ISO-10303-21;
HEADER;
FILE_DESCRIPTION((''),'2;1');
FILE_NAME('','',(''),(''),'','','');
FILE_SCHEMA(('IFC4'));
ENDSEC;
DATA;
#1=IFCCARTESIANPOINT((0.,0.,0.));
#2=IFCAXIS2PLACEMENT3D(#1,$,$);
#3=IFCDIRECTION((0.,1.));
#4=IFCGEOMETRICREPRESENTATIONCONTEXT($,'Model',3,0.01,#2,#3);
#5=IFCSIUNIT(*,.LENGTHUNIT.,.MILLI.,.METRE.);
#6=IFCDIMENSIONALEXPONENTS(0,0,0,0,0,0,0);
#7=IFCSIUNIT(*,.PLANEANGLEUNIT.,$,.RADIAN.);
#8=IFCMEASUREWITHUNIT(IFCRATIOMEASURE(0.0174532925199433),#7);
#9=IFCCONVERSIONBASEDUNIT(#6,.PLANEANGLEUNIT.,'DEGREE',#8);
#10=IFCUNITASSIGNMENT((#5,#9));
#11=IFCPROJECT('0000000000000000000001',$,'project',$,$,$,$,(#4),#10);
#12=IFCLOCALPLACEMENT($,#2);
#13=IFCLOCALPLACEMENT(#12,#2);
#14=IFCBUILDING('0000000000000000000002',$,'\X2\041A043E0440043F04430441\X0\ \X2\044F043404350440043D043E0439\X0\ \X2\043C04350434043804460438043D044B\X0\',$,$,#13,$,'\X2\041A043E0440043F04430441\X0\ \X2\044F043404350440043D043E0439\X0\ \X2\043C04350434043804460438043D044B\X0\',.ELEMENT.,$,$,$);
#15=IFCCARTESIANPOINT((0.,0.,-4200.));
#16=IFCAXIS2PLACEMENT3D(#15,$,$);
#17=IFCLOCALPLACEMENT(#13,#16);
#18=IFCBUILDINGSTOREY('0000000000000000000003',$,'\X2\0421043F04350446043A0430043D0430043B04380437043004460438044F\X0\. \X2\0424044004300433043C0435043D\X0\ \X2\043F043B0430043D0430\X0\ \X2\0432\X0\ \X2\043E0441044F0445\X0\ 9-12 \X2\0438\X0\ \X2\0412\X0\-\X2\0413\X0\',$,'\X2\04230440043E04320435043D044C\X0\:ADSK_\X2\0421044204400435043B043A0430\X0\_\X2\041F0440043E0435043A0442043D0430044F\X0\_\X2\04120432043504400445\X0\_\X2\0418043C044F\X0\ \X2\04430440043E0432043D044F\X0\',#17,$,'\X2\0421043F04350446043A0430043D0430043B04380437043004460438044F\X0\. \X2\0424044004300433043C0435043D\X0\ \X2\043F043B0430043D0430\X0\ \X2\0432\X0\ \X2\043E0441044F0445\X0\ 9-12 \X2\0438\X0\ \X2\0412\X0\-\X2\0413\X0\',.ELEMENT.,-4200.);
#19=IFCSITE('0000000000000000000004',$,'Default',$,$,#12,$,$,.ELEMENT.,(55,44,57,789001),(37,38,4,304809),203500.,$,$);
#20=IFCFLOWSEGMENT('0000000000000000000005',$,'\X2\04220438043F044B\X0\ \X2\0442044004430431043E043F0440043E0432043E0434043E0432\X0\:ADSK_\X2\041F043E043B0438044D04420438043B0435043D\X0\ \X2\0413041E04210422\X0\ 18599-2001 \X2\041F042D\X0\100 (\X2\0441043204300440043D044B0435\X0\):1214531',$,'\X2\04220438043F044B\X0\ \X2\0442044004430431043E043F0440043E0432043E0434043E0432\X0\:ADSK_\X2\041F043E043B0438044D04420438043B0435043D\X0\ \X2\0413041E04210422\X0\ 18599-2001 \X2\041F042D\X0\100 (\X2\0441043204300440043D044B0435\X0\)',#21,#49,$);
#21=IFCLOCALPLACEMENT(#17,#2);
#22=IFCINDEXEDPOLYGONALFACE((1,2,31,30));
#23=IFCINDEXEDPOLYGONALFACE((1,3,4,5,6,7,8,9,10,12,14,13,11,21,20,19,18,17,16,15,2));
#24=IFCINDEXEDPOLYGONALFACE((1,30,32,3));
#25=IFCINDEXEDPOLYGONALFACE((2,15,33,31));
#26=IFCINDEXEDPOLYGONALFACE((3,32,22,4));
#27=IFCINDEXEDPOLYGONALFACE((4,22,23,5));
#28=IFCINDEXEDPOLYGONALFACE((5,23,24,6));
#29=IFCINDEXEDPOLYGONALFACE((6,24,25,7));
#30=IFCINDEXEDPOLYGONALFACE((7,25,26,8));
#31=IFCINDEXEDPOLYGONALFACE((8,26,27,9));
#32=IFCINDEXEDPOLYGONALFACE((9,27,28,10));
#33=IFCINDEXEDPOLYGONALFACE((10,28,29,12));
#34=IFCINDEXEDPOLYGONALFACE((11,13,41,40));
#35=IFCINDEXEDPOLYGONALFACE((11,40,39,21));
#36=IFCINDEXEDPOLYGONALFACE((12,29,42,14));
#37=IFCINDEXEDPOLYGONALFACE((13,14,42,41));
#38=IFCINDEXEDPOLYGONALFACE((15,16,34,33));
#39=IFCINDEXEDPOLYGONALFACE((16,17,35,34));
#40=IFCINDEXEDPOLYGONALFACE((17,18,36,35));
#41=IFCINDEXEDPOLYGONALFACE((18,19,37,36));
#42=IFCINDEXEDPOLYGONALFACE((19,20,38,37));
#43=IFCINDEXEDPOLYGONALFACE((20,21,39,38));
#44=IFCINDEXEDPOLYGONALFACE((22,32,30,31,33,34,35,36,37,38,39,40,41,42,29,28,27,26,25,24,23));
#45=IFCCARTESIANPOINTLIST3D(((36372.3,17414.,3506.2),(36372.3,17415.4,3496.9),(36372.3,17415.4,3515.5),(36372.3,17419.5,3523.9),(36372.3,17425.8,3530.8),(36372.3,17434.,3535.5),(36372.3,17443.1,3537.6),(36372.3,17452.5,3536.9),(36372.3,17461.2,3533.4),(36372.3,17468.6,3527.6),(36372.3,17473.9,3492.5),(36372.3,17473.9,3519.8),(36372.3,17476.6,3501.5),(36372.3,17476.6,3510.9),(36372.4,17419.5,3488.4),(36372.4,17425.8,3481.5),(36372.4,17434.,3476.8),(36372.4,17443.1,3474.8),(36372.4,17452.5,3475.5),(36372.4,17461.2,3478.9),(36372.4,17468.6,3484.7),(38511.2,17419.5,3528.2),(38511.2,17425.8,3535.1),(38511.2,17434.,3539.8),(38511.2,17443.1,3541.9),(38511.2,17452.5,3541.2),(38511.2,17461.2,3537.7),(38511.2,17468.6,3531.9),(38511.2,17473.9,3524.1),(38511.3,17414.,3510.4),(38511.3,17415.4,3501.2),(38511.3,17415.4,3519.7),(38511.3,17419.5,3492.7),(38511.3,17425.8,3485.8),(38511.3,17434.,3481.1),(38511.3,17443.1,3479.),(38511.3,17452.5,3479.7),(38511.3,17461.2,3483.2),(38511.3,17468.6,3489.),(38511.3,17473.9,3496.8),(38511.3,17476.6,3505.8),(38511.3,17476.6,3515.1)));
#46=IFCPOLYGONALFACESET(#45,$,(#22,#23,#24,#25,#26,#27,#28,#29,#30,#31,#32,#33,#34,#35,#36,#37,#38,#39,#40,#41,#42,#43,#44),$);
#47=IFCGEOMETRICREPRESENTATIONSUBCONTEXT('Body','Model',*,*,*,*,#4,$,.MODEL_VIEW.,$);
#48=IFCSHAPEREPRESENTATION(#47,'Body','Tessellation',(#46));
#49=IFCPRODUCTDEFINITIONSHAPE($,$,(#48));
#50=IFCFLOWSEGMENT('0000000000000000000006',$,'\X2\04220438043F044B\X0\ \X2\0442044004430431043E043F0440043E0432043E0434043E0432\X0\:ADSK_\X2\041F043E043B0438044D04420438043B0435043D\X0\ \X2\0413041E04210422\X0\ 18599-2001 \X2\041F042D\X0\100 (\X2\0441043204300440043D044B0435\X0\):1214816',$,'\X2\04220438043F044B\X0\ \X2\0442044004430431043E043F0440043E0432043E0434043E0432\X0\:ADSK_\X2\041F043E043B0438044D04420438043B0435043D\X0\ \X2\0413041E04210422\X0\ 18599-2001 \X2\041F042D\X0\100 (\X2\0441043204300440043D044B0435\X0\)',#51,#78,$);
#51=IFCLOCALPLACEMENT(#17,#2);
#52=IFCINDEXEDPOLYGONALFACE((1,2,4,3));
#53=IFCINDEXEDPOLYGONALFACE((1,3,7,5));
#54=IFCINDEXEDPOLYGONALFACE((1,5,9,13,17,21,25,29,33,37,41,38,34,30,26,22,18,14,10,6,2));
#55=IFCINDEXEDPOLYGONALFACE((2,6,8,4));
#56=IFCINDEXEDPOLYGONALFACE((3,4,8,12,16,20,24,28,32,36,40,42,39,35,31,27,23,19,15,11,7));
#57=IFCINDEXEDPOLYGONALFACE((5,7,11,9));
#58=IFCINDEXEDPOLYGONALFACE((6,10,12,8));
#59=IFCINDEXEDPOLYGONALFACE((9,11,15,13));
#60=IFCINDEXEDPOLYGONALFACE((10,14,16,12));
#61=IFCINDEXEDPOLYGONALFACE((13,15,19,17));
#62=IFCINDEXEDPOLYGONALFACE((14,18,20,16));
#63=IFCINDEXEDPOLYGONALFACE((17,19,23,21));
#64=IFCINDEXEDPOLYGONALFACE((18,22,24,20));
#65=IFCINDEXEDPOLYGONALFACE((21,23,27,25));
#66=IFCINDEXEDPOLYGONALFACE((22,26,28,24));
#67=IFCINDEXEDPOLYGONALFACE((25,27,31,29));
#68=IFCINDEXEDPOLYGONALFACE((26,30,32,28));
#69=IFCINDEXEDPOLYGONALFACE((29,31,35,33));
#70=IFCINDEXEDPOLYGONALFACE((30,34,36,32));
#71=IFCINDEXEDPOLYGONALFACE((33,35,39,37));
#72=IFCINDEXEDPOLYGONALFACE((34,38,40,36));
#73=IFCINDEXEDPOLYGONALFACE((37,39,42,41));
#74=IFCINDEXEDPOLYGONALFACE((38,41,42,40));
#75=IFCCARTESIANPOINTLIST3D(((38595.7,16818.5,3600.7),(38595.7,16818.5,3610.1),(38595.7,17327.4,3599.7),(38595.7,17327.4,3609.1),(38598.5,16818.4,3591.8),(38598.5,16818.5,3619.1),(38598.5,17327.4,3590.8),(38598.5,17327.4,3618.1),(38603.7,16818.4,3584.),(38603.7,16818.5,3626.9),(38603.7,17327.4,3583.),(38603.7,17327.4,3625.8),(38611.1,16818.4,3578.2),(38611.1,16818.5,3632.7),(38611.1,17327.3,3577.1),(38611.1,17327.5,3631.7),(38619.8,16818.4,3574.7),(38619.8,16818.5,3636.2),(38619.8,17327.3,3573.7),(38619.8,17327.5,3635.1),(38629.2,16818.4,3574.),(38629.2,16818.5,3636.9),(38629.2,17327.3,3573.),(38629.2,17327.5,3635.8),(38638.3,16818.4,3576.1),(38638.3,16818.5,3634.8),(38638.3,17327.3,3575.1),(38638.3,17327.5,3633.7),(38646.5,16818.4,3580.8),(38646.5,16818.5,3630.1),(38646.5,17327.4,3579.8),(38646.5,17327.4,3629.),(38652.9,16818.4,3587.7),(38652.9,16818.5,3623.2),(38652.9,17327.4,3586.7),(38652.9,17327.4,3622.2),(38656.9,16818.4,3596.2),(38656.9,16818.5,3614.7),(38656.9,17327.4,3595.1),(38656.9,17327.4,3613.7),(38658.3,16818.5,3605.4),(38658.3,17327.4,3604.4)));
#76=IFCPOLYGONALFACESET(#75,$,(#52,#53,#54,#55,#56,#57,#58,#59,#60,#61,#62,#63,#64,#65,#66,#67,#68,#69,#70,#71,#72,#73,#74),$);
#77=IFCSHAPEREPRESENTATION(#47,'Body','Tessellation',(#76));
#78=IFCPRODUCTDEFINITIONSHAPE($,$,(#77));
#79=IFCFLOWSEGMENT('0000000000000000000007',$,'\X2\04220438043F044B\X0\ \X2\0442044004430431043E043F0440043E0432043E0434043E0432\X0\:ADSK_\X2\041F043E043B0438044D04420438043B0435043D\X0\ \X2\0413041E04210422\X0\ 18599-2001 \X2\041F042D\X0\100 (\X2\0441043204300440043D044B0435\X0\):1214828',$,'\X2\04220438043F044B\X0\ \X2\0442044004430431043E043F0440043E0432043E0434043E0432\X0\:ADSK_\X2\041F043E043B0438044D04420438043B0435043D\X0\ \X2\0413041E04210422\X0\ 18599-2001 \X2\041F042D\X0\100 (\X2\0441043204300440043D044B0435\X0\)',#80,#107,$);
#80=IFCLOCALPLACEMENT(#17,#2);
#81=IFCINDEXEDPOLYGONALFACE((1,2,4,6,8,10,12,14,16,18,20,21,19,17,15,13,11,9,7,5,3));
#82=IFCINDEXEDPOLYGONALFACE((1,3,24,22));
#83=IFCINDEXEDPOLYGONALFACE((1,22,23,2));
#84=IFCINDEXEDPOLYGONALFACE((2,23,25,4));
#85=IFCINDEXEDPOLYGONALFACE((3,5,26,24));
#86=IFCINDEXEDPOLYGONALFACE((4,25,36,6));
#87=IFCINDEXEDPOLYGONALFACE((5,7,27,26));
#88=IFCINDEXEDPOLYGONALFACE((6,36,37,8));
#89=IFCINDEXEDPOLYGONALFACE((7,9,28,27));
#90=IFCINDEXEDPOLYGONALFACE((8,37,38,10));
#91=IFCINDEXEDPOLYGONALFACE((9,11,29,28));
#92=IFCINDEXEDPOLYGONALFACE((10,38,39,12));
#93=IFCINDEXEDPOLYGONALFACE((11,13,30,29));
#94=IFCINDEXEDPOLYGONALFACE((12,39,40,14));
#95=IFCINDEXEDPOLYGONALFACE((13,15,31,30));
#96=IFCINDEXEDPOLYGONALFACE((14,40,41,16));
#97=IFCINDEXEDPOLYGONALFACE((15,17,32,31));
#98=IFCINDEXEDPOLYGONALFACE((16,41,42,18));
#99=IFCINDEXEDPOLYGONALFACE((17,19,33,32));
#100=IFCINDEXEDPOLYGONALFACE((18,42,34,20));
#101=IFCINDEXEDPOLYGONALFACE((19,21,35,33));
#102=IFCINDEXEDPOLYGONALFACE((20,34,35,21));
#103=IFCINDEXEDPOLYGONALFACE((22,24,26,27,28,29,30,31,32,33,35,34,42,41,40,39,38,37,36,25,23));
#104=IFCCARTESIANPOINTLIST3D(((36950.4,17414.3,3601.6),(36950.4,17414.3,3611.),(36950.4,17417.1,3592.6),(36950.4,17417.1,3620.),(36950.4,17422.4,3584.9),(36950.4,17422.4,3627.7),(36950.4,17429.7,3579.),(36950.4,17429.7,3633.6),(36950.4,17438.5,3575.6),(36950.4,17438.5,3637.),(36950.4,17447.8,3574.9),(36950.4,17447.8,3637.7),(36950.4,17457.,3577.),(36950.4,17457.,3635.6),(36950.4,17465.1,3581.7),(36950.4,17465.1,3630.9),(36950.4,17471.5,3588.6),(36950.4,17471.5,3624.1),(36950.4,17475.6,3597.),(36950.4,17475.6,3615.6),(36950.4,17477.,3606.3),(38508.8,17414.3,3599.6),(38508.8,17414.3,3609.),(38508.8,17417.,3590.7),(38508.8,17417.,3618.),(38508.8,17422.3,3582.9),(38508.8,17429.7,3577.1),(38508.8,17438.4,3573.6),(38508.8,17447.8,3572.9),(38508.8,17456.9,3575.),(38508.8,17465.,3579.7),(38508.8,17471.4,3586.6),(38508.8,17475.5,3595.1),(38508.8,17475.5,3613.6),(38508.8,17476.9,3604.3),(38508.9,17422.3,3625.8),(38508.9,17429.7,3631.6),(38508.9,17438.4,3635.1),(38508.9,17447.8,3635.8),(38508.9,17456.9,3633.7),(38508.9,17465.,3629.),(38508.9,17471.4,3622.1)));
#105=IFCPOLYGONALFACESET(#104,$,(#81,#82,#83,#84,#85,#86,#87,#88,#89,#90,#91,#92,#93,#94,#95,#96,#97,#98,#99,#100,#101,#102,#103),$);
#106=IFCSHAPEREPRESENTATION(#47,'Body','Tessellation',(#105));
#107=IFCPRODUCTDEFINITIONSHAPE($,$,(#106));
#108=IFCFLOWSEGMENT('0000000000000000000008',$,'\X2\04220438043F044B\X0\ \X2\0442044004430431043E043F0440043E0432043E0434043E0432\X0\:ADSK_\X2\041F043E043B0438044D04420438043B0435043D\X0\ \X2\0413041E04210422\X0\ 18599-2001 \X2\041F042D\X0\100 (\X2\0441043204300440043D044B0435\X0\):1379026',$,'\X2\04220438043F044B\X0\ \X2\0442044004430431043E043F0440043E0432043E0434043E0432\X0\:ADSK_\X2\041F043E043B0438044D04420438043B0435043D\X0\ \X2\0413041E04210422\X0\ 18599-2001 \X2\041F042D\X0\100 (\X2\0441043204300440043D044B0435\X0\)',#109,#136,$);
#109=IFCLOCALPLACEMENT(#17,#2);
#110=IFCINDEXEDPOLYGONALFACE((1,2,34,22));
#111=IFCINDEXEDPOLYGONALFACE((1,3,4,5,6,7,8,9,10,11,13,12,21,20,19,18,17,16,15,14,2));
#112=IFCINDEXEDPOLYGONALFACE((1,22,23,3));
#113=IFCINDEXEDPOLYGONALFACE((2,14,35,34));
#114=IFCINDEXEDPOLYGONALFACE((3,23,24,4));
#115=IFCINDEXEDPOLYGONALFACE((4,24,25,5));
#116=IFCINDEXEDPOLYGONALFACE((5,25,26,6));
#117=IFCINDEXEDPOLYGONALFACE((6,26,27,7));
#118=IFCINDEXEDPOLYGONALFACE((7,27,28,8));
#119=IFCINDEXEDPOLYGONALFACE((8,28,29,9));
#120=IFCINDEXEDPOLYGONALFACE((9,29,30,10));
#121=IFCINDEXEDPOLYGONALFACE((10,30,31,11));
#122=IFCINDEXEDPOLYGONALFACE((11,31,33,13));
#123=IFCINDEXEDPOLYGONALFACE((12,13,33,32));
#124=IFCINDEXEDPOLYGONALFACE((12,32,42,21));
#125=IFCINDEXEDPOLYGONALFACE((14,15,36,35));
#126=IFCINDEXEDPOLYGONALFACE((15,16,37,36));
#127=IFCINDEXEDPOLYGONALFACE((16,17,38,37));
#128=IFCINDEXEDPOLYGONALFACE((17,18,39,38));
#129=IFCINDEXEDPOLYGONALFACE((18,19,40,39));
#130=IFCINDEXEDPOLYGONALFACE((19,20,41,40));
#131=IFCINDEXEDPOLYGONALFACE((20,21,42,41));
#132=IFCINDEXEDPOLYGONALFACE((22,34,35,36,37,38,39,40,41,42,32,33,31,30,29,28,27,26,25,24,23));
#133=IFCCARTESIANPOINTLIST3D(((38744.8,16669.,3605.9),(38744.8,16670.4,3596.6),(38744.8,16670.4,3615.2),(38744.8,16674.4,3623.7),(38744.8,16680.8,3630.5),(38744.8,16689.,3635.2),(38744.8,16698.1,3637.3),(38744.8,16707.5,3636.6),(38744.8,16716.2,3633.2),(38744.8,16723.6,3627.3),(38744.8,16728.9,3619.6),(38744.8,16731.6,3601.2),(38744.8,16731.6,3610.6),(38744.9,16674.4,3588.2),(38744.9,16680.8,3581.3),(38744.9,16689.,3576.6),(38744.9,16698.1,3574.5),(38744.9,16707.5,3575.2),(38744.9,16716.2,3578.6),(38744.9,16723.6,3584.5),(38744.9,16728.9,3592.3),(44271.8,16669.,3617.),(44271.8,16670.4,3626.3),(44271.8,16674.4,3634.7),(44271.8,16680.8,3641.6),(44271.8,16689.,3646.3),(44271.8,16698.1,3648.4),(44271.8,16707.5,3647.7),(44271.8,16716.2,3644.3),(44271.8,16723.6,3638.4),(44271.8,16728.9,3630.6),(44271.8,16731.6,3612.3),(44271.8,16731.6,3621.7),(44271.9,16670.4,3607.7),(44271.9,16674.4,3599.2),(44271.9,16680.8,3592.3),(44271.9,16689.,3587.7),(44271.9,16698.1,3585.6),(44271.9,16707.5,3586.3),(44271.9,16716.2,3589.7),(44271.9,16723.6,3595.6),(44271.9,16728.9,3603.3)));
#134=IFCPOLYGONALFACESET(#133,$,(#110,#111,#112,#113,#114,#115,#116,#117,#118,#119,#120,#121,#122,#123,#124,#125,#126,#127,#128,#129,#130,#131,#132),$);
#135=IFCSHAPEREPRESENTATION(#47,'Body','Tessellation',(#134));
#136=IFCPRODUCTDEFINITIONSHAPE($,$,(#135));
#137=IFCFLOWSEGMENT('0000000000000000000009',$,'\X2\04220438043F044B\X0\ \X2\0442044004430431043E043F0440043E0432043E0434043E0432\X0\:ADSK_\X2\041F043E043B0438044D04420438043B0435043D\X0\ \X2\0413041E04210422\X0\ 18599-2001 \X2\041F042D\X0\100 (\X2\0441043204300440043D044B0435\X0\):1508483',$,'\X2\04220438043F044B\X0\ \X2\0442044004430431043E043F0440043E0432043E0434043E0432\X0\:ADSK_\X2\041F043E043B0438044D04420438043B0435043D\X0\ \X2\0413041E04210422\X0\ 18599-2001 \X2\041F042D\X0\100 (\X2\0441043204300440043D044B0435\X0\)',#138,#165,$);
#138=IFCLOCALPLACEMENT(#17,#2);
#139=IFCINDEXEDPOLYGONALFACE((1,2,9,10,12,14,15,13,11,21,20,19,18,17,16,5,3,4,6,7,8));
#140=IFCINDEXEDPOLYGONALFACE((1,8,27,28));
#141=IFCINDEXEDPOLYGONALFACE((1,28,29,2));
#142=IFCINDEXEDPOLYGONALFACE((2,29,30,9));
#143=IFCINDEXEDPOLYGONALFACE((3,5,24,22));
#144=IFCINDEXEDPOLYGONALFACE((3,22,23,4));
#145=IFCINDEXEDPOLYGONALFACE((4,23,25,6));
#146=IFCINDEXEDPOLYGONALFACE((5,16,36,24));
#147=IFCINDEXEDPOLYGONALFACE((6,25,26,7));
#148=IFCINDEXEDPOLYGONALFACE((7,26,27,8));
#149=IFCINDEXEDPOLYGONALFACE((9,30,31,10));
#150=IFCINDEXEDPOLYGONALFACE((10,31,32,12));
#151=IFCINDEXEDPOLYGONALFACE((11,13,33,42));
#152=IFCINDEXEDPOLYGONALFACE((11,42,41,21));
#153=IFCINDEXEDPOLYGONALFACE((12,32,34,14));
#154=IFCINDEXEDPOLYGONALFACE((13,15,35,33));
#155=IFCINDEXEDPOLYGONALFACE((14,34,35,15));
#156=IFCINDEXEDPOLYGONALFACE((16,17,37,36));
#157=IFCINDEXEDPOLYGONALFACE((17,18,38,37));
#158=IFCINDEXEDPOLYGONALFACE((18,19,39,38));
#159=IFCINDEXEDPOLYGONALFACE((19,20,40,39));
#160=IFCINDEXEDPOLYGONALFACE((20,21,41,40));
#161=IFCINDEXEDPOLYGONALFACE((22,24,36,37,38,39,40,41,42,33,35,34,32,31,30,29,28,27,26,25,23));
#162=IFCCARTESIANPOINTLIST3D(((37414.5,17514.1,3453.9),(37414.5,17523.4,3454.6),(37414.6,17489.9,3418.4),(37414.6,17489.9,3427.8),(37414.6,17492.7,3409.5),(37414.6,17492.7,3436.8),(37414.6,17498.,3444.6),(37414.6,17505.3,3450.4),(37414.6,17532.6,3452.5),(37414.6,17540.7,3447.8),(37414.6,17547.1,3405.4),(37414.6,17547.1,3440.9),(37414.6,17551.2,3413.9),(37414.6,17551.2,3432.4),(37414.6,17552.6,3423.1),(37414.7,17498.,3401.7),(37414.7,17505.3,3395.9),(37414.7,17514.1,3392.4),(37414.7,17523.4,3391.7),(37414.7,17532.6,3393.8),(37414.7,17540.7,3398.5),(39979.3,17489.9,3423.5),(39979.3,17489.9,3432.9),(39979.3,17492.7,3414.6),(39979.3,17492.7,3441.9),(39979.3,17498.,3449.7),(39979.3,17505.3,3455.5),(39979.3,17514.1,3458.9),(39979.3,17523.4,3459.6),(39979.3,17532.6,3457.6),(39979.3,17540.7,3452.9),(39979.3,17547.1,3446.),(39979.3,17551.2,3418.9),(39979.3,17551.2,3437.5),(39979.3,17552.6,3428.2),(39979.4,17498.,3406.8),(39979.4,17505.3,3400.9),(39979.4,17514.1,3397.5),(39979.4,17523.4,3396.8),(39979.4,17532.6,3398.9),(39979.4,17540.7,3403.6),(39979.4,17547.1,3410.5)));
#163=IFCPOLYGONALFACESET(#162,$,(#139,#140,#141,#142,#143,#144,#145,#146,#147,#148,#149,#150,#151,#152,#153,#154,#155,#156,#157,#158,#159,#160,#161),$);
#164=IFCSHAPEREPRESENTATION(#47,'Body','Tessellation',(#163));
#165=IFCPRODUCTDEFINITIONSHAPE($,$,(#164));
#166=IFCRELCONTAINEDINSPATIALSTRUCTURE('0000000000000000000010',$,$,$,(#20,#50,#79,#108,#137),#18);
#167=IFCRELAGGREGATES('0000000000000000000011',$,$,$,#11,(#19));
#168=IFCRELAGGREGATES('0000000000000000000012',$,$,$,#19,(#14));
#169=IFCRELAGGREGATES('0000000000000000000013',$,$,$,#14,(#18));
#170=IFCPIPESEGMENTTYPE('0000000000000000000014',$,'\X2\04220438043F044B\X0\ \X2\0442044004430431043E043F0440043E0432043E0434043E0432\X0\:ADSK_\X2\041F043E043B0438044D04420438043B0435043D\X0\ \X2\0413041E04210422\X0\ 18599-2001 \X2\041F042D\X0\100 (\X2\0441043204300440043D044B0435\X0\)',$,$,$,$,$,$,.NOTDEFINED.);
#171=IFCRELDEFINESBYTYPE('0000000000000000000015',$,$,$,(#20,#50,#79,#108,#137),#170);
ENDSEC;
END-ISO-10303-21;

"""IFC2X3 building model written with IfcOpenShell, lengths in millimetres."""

from ifc_helpers import new_model, entity, si_unit, converted_unit, direction, frame, origin, origin_2d_with_axis, place, context, subcontext, project, spatial, circle, extrude, type_object, element, save


model = new_model("IFC2X3")

# Units and contexts
model_context = context("Model", 3, precision=0.01, world=origin(), true_north=direction((0.0, 1.0)))
body_context = subcontext(model_context, "Body", "Model", "MODEL_VIEW")
ifc_project = project(units=[si_unit("LENGTHUNIT", "METRE", prefix="MILLI"), converted_unit("PLANEANGLEUNIT", "DEGREE", entity("IfcRatioMeasure", 0.0174532925199433), si_unit("PLANEANGLEUNIT", "RADIAN"), dimensions=[0, 0, 0, 0, 0, 0, 0])], contexts=[model_context])

# Site, building, storey
site_placement = place(None, origin())
site = spatial("IfcSite", under=ifc_project, at=site_placement, Name="Default", CompositionType="ELEMENT", RefLatitude=(55, 44, 57, 789001), RefLongitude=(37, 38, 4, 304809), RefElevation=203500.0)
building_placement = place(site_placement, origin())
building = spatial("IfcBuilding", under=site, at=building_placement, Name="Корпус ядерной медицины", LongName="Корпус ядерной медицины", CompositionType="ELEMENT")
storey_placement = place(building_placement, frame((0.0, 0.0, -4200.0)))
storey = spatial("IfcBuildingStorey", under=building, at=storey_placement, Name="Спецканализация. Фрагмен плана в осях 9-12 и В-Г", ObjectType="Уровень:ADSK_Стрелка_Проектная_Вверх_Имя уровня", LongName="Спецканализация. Фрагмен плана в осях 9-12 и В-Г", CompositionType="ELEMENT", Elevation=-4200.0)

# Flow segments
pipe_segment_type = type_object("IfcPipeSegmentType", Name="Типы трубопроводов:ADSK_Полиэтилен ГОСТ 18599-2001 ПЭ100 (сварные)", PredefinedType="NOTDEFINED")
flow_segment_1_placement = place(storey_placement, frame((36372.3, 17412.4, 3473.1)))
element("IfcFlowSegment", 1, at=flow_segment_1_placement, inside=storey, type_object=pipe_segment_type, Name="Типы трубопроводов:ADSK_Полиэтилен ГОСТ 18599-2001 ПЭ100 (сварные):1214531", ObjectType="Типы трубопроводов:ADSK_Полиэтилен ГОСТ 18599-2001 ПЭ100 (сварные)", context=body_context, shape_type="SweptSolid", body=[
    extrude(circle(Radius=31.5, at=origin_2d_with_axis()), frame((0.1, 33.1, 33.1), z_axis=(0.999998, 0.0, 0.002), x_axis=(0.0, -1.0, 0.0)), (0.0, 0.0, 1.0), 2139.0),
])
flow_segment_2_placement = place(storey_placement, frame((38593.7, 16818.4, 3571.3)))
element("IfcFlowSegment", 2, at=flow_segment_2_placement, inside=storey, type_object=pipe_segment_type, Name="Типы трубопроводов:ADSK_Полиэтилен ГОСТ 18599-2001 ПЭ100 (сварные):1214816", ObjectType="Типы трубопроводов:ADSK_Полиэтилен ГОСТ 18599-2001 ПЭ100 (сварные)", context=body_context, shape_type="SweptSolid", body=[
    extrude(circle(Radius=31.5, at=origin_2d_with_axis()), frame((33.1, 509.0, 33.1), z_axis=(0.0, -0.999998, 0.002007), x_axis=(1.0, 0.0, 0.0)), (0.0, 0.0, 1.0), 508.9),
])
flow_segment_3_placement = place(storey_placement, frame((36950.4, 17412.3, 3571.2)))
element("IfcFlowSegment", 3, at=flow_segment_3_placement, inside=storey, type_object=pipe_segment_type, Name="Типы трубопроводов:ADSK_Полиэтилен ГОСТ 18599-2001 ПЭ100 (сварные):1214828", ObjectType="Типы трубопроводов:ADSK_Полиэтилен ГОСТ 18599-2001 ПЭ100 (сварные)", context=body_context, shape_type="SweptSolid", body=[
    extrude(circle(Radius=31.5, at=origin_2d_with_axis()), frame((1558.5, 33.1, 33.1), z_axis=(-0.999999, 0.000046, 0.001263), x_axis=(0.000046, 1.0, 0.0)), (0.0, 0.0, 1.0), 1558.4),
])
flow_segment_4_placement = place(storey_placement, frame((38744.8, 16667.4, 3572.8)))
element("IfcFlowSegment", 4, at=flow_segment_4_placement, inside=storey, type_object=pipe_segment_type, Name="Типы трубопроводов:ADSK_Полиэтилен ГОСТ 18599-2001 ПЭ100 (сварные):1379026", ObjectType="Типы трубопроводов:ADSK_Полиэтилен ГОСТ 18599-2001 ПЭ100 (сварные)", context=body_context, shape_type="SweptSolid", body=[
    extrude(circle(Radius=31.5, at=origin_2d_with_axis()), frame((0.1, 33.1, 33.1), z_axis=(0.999998, 0.0, 0.002001), x_axis=(0.0, -1.0, 0.0)), (0.0, 0.0, 1.0), 5527.0),
])
flow_segment_5_placement = place(storey_placement, frame((37414.6, 17488.0, 3390.0)))
element("IfcFlowSegment", 5, at=flow_segment_5_placement, inside=storey, type_object=pipe_segment_type, Name="Типы трубопроводов:ADSK_Полиэтилен ГОСТ 18599-2001 ПЭ100 (сварные):1508483", ObjectType="Типы трубопроводов:ADSK_Полиэтилен ГОСТ 18599-2001 ПЭ100 (сварные)", context=body_context, shape_type="SweptSolid", body=[
    extrude(circle(Radius=31.5, at=origin_2d_with_axis()), frame((0.1, 33.1, 33.1), z_axis=(0.999998, 0.0, 0.001985), x_axis=(0.0, 1.0, 0.0)), (0.0, 0.0, 1.0), 2564.7),
])

save(model, "model.ifc")
